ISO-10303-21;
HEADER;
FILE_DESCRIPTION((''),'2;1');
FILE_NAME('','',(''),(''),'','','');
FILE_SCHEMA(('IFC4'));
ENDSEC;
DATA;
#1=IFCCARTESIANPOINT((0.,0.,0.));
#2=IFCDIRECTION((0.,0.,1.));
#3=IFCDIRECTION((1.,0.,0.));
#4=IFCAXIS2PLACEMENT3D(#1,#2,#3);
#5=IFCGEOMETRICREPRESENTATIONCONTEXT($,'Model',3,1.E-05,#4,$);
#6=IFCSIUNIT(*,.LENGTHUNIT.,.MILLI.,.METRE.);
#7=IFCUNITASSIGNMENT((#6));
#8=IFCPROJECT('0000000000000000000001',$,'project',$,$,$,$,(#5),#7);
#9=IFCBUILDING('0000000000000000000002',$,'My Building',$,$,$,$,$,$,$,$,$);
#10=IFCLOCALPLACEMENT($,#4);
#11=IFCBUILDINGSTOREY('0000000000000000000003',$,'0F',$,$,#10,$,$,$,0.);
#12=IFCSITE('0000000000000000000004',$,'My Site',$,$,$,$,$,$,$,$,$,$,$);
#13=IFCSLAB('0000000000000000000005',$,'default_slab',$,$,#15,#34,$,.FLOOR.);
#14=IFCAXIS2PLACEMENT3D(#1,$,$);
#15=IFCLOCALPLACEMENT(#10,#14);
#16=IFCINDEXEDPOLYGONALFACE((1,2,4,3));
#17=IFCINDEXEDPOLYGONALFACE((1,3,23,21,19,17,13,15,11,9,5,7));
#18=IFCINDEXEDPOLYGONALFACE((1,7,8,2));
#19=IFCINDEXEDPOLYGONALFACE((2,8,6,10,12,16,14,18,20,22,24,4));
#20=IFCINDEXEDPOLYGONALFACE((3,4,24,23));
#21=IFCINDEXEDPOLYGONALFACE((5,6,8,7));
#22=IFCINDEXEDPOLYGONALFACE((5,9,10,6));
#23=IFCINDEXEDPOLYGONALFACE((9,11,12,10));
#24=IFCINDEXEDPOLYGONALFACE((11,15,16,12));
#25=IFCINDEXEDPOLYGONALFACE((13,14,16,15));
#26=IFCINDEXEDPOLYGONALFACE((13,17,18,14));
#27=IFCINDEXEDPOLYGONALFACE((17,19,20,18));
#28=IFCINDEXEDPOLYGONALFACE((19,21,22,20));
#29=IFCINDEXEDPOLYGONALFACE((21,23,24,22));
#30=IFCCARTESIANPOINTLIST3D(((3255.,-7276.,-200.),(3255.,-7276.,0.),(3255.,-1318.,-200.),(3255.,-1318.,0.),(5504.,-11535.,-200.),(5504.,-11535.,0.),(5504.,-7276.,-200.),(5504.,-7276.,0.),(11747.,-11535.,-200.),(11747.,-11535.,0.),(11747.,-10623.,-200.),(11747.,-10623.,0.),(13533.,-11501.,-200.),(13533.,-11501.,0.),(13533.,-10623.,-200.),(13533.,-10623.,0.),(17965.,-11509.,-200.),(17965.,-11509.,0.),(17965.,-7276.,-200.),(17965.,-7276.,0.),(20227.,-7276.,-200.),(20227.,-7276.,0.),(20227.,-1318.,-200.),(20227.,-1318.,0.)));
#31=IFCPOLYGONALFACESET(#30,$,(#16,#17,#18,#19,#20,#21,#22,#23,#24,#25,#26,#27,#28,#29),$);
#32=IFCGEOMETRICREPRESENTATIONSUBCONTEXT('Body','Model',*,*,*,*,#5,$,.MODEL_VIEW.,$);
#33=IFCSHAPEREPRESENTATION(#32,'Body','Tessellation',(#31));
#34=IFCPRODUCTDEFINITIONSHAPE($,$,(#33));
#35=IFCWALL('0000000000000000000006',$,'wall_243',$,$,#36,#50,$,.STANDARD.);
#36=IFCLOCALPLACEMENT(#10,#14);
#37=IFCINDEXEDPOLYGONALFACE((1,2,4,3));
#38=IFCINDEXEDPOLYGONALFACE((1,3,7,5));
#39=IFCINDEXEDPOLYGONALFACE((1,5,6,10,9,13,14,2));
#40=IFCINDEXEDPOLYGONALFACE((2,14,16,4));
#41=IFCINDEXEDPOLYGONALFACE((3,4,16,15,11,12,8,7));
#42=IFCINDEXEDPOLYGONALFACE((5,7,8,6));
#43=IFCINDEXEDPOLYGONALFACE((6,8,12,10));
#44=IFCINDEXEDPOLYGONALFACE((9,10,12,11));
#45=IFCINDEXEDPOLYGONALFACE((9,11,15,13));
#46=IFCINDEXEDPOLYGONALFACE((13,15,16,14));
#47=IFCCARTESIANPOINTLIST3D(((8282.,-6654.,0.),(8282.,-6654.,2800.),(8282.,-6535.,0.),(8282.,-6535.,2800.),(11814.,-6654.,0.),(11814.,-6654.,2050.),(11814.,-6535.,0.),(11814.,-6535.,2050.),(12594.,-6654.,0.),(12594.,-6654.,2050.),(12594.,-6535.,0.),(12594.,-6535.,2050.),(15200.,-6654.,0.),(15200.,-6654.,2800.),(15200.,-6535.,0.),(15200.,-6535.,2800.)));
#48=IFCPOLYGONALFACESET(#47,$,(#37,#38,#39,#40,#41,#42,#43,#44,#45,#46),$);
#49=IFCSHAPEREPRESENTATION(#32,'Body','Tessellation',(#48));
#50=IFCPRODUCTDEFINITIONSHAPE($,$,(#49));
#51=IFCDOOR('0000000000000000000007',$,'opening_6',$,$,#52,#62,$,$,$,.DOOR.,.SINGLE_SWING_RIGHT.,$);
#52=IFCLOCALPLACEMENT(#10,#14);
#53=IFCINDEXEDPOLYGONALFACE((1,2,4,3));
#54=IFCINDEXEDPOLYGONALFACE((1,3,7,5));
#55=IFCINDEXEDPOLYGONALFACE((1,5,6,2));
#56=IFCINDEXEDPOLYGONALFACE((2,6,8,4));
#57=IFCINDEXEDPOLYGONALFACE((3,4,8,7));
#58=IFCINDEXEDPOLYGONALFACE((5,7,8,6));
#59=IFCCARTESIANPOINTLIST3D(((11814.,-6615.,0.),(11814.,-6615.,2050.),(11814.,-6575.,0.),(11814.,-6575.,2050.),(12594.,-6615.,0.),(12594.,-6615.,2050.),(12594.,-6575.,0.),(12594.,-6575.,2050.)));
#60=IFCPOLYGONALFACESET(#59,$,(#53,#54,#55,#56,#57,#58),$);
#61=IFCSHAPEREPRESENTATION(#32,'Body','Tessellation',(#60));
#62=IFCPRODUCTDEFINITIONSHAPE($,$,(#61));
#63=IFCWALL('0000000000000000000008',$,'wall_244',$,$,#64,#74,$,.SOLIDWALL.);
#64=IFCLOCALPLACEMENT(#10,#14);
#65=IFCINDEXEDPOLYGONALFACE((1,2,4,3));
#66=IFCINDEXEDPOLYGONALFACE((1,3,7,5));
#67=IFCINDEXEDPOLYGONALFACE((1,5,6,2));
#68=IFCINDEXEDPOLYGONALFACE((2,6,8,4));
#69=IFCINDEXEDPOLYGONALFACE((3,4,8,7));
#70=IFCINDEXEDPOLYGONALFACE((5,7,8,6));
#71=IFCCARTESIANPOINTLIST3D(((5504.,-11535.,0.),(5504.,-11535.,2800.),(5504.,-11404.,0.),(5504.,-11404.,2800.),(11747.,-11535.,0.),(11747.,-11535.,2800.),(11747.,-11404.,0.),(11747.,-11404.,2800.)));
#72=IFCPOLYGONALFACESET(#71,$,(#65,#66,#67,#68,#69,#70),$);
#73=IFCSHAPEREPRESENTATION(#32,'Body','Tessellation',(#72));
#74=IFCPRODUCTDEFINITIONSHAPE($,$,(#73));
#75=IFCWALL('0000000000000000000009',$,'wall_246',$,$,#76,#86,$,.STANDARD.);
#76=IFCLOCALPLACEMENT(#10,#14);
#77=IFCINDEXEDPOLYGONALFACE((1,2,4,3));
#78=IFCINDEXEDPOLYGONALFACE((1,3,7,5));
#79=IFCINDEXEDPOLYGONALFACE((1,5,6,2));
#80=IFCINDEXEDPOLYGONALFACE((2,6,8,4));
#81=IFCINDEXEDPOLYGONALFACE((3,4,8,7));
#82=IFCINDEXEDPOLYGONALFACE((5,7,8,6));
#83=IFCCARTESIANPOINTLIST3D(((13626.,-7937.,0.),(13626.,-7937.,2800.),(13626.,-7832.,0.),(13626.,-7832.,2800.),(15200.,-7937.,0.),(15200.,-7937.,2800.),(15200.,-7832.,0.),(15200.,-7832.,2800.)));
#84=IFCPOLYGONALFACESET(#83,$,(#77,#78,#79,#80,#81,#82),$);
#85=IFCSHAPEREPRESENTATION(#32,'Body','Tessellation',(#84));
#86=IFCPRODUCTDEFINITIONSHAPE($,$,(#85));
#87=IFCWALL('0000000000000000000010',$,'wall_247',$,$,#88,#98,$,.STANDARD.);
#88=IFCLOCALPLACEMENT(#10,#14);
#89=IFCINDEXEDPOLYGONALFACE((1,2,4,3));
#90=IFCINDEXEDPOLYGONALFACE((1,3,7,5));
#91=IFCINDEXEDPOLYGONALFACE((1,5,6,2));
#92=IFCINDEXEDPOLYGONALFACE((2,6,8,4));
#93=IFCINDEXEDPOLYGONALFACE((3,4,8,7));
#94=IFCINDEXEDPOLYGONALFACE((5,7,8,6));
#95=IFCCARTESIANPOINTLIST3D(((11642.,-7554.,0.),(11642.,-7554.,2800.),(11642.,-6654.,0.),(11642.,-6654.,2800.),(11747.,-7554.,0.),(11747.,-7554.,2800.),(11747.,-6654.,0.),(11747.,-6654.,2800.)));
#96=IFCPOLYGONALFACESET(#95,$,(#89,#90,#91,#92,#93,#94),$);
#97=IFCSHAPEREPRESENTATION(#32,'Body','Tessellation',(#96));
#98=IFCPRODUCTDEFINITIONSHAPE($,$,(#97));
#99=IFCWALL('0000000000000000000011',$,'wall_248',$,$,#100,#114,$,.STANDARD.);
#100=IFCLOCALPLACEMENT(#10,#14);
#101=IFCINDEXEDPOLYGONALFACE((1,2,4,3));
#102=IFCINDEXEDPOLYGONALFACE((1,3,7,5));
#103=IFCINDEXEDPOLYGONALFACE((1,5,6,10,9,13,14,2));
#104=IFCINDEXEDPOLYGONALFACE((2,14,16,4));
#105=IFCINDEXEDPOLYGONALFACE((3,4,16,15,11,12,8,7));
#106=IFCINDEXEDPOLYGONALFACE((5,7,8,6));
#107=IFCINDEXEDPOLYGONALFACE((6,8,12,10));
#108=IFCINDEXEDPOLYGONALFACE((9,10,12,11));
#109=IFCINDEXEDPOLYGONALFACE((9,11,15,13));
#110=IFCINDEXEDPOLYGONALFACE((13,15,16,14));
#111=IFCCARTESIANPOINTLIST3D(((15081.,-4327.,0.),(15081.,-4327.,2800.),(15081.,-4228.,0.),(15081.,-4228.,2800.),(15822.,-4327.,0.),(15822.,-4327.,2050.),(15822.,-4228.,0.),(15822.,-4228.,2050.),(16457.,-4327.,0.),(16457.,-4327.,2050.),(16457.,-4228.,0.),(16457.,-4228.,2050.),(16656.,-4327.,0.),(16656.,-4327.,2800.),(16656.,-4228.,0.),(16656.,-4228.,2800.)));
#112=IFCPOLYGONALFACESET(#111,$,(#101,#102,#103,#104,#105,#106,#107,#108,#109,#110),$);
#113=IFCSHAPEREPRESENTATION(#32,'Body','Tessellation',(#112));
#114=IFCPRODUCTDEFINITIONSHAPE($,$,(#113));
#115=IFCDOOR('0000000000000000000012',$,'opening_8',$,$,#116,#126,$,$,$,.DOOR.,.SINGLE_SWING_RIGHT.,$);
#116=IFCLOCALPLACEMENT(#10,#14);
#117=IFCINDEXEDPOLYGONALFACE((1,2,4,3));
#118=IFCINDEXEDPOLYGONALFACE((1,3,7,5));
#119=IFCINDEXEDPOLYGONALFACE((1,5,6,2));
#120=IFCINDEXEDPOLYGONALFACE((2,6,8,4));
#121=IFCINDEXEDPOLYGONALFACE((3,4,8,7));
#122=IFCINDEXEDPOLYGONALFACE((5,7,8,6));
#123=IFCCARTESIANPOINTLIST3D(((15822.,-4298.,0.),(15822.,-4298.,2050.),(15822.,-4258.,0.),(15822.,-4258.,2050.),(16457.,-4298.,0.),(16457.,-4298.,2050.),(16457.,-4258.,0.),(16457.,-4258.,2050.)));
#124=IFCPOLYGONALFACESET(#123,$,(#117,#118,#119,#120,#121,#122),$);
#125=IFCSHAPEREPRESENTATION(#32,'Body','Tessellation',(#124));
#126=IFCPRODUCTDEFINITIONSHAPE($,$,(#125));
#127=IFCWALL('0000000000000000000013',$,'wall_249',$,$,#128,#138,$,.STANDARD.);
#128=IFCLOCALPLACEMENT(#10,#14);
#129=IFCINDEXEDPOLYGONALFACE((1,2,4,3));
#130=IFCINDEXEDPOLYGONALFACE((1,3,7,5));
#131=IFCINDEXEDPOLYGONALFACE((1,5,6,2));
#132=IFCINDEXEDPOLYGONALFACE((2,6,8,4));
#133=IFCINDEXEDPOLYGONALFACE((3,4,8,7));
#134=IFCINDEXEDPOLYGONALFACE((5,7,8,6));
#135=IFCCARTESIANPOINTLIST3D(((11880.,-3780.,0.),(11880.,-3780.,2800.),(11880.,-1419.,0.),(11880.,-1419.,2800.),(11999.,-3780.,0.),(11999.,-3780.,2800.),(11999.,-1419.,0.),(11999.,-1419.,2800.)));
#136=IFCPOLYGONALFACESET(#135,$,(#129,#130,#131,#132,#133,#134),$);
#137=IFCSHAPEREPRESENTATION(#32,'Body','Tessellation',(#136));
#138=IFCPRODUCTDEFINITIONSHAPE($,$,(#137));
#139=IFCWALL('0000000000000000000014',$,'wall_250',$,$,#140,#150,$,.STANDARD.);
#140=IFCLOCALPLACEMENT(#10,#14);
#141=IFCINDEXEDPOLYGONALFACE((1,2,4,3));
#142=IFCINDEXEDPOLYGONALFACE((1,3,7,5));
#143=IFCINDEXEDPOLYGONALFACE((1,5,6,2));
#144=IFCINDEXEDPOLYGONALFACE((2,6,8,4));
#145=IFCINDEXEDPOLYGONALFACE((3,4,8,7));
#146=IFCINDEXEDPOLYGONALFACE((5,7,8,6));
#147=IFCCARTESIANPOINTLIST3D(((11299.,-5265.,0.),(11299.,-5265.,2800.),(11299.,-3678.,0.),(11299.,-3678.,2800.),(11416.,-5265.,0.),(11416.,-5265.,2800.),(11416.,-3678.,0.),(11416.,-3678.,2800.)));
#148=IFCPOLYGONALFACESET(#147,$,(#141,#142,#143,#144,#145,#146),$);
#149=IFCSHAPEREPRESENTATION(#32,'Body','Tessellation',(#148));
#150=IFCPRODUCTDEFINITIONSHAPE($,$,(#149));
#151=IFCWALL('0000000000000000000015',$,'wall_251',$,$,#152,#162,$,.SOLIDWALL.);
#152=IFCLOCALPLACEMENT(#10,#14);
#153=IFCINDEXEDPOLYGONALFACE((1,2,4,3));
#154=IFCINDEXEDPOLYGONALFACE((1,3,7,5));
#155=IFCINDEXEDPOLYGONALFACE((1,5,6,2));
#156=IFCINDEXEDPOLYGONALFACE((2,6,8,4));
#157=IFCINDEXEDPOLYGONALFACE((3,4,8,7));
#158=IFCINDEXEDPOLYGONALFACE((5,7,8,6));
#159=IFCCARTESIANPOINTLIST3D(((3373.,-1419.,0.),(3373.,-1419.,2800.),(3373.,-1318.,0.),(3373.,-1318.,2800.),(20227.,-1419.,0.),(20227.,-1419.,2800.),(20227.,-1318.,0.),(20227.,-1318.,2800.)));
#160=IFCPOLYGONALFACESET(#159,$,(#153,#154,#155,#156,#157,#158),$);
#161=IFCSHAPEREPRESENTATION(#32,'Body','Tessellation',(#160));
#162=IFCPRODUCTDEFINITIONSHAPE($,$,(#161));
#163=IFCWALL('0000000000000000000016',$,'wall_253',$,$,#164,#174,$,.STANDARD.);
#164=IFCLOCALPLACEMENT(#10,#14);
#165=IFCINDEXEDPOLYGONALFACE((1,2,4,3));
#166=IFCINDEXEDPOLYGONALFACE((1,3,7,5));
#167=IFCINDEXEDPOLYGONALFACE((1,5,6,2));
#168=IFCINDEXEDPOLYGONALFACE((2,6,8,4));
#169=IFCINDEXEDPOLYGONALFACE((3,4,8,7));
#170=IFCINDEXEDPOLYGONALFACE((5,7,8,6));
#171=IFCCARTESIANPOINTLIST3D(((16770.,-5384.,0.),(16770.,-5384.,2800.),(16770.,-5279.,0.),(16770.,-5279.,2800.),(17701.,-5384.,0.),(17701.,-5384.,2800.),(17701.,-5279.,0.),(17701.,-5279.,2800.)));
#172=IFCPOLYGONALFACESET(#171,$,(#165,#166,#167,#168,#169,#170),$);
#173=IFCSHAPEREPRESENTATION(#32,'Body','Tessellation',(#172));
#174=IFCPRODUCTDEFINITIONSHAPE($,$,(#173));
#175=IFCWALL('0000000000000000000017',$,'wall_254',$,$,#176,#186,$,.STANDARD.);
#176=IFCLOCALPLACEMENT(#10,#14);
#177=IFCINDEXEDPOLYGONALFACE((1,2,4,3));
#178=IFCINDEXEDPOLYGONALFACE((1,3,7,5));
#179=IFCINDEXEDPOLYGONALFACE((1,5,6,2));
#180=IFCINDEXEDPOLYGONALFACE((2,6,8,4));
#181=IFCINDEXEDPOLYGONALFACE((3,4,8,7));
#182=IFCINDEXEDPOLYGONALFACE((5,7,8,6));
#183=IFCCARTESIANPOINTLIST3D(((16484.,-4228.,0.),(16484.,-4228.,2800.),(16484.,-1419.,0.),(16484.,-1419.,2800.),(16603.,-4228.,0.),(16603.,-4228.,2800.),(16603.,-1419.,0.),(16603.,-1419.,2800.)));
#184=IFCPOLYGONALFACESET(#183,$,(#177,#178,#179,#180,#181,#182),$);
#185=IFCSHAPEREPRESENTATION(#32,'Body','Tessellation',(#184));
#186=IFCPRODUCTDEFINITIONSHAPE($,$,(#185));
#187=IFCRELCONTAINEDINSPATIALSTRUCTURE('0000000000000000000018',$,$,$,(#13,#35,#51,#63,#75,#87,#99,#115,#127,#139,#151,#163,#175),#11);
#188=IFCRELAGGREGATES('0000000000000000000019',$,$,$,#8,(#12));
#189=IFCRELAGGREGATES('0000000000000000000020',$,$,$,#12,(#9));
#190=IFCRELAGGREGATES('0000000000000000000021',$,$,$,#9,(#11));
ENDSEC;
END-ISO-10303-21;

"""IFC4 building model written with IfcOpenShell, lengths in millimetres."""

from ifc_helpers import new_model, si_unit, origin_with_axes, place, context, subcontext, project, spatial, indexed_curve, outline, extrude, element, fill, save


model = new_model("IFC4")

# Units and contexts
model_context = context("Model", 3, precision=1e-05, world=origin_with_axes())
body_context = subcontext(model_context, "Body", "Model", "MODEL_VIEW")
ifc_project = project(units=[si_unit("LENGTHUNIT", "METRE", prefix="MILLI")], contexts=[model_context])

# Site, building, storey
site = spatial("IfcSite", under=ifc_project, Name="My Site")
building = spatial("IfcBuilding", under=site, Name="My Building")
storey_placement = place(None, origin_with_axes())
storey = spatial("IfcBuildingStorey", under=building, at=storey_placement, Name="0F", Elevation=0.0)

# Slab
slab_placement = place(storey_placement, origin_with_axes())
element("IfcSlab", 1, at=slab_placement, inside=storey, Name="default_slab", PredefinedType="FLOOR", context=body_context, shape_type="SweptSolid", body=[
    extrude(outline(indexed_curve([(5504.0, -7276.0), (5504.0, -11535.0), (11747.0, -11535.0), (11747.0, -10623.0), (13533.0, -10623.0), (13533.0, -11501.0), (17965.0, -11509.0), (17965.0, -7276.0), (20227.0, -7276.0), (20227.0, -1318.0), (3255.0, -1318.0), (3255.0, -7276.0), (5504.0, -7276.0)])), None, (0.0, 0.0, -1.0), 200.0),
])

# Wall, opening, door
wall_1_placement = place(storey_placement, origin_with_axes())
wall_1 = element("IfcWall", 2, at=wall_1_placement, inside=storey, Name="wall_243", PredefinedType="STANDARD", context=body_context, shape_type="SweptSolid", body=[
    extrude(outline(indexed_curve([(8282.0, -6654.0), (15200.0, -6654.0), (15200.0, -6535.0), (8282.0, -6535.0), (8282.0, -6654.0)])), None, (0.0, 0.0, 1.0), 2800.0),
])
opening_1_placement = place(wall_1_placement, origin_with_axes())
opening_1 = element("IfcOpeningElement", 3, at=opening_1_placement, cuts=wall_1, ObjectType="Opening", context=body_context, shape_type="SweptSolid", body=[
    extrude(outline(indexed_curve([(12594.0, -6720.0), (12594.0, -6469.0), (11814.0, -6469.0), (11814.0, -6720.0), (12594.0, -6720.0)])), None, (0.0, 0.0, 1.0), 2050.0),
])
door_1_placement = place(opening_1_placement, origin_with_axes())
door_1 = element("IfcDoor", 4, at=door_1_placement, inside=storey, Name="opening_6", OperationType="SINGLE_SWING_RIGHT", PredefinedType="DOOR", context=body_context, shape_type="SweptSolid", body=[
    extrude(outline(indexed_curve([(12594.0, -6615.0), (12594.0, -6575.0), (11814.0, -6575.0), (11814.0, -6615.0), (12594.0, -6615.0)])), None, (0.0, 0.0, 1.0), 2050.0),
])
fill(opening_1, door_1)

# Walls
wall_2_placement = place(storey_placement, origin_with_axes())
element("IfcWall", 5, at=wall_2_placement, inside=storey, Name="wall_244", PredefinedType="SOLIDWALL", context=body_context, shape_type="SweptSolid", body=[
    extrude(outline(indexed_curve([(5504.0, -11535.0), (11747.0, -11535.0), (11747.0, -11404.0), (5504.0, -11404.0), (5504.0, -11535.0)])), None, (0.0, 0.0, 1.0), 2800.0),
])
wall_3_placement = place(storey_placement, origin_with_axes())
element("IfcWall", 6, at=wall_3_placement, inside=storey, Name="wall_246", PredefinedType="STANDARD", context=body_context, shape_type="SweptSolid", body=[
    extrude(outline(indexed_curve([(13626.0, -7937.0), (15200.0, -7937.0), (15200.0, -7832.0), (13626.0, -7832.0), (13626.0, -7937.0)])), None, (0.0, 0.0, 1.0), 2800.0),
])
wall_4_placement = place(storey_placement, origin_with_axes())
element("IfcWall", 7, at=wall_4_placement, inside=storey, Name="wall_247", PredefinedType="STANDARD", context=body_context, shape_type="SweptSolid", body=[
    extrude(outline(indexed_curve([(11642.0, -6654.0), (11642.0, -7554.0), (11747.0, -7554.0), (11747.0, -6654.0), (11642.0, -6654.0)])), None, (0.0, 0.0, 1.0), 2800.0),
])

# Wall, opening, door
wall_5_placement = place(storey_placement, origin_with_axes())
wall_5 = element("IfcWall", 8, at=wall_5_placement, inside=storey, Name="wall_248", PredefinedType="STANDARD", context=body_context, shape_type="SweptSolid", body=[
    extrude(outline(indexed_curve([(15081.0, -4327.0), (16656.0, -4327.0), (16656.0, -4228.0), (15081.0, -4228.0), (15081.0, -4327.0)])), None, (0.0, 0.0, 1.0), 2800.0),
])
opening_2_placement = place(wall_5_placement, origin_with_axes())
opening_2 = element("IfcOpeningElement", 9, at=opening_2_placement, cuts=wall_5, ObjectType="Opening", context=body_context, shape_type="SweptSolid", body=[
    extrude(outline(indexed_curve([(16457.0, -4393.0), (16457.0, -4162.0), (15822.0, -4162.0), (15822.0, -4393.0), (16457.0, -4393.0)])), None, (0.0, 0.0, 1.0), 2050.0),
])
door_2_placement = place(opening_2_placement, origin_with_axes())
door_2 = element("IfcDoor", 10, at=door_2_placement, inside=storey, Name="opening_8", OperationType="SINGLE_SWING_RIGHT", PredefinedType="DOOR", context=body_context, shape_type="SweptSolid", body=[
    extrude(outline(indexed_curve([(16457.0, -4298.0), (16457.0, -4258.0), (15822.0, -4258.0), (15822.0, -4298.0), (16457.0, -4298.0)])), None, (0.0, 0.0, 1.0), 2050.0),
])
fill(opening_2, door_2)

# Walls
wall_6_placement = place(storey_placement, origin_with_axes())
element("IfcWall", 11, at=wall_6_placement, inside=storey, Name="wall_249", PredefinedType="STANDARD", context=body_context, shape_type="SweptSolid", body=[
    extrude(outline(indexed_curve([(11880.0, -1419.0), (11880.0, -3780.0), (11999.0, -3780.0), (11999.0, -1419.0), (11880.0, -1419.0)])), None, (0.0, 0.0, 1.0), 2800.0),
])
wall_7_placement = place(storey_placement, origin_with_axes())
element("IfcWall", 12, at=wall_7_placement, inside=storey, Name="wall_250", PredefinedType="STANDARD", context=body_context, shape_type="SweptSolid", body=[
    extrude(outline(indexed_curve([(11299.0, -3678.0), (11299.0, -5265.0), (11416.0, -5265.0), (11416.0, -3678.0), (11299.0, -3678.0)])), None, (0.0, 0.0, 1.0), 2800.0),
])
wall_8_placement = place(storey_placement, origin_with_axes())
element("IfcWall", 13, at=wall_8_placement, inside=storey, Name="wall_251", PredefinedType="SOLIDWALL", context=body_context, shape_type="SweptSolid", body=[
    extrude(outline(indexed_curve([(3373.0, -1419.0), (20227.0, -1419.0), (20227.0, -1318.0), (3373.0, -1318.0), (3373.0, -1419.0)])), None, (0.0, 0.0, 1.0), 2800.0),
])
wall_9_placement = place(storey_placement, origin_with_axes())
element("IfcWall", 14, at=wall_9_placement, inside=storey, Name="wall_253", PredefinedType="STANDARD", context=body_context, shape_type="SweptSolid", body=[
    extrude(outline(indexed_curve([(16770.0, -5384.0), (17701.0, -5384.0), (17701.0, -5279.0), (16770.0, -5279.0), (16770.0, -5384.0)])), None, (0.0, 0.0, 1.0), 2800.0),
])
wall_10_placement = place(storey_placement, origin_with_axes())
element("IfcWall", 15, at=wall_10_placement, inside=storey, Name="wall_254", PredefinedType="STANDARD", context=body_context, shape_type="SweptSolid", body=[
    extrude(outline(indexed_curve([(16484.0, -1419.0), (16484.0, -4228.0), (16603.0, -4228.0), (16603.0, -1419.0), (16484.0, -1419.0)])), None, (0.0, 0.0, 1.0), 2800.0),
])

save(model, "model.ifc")
